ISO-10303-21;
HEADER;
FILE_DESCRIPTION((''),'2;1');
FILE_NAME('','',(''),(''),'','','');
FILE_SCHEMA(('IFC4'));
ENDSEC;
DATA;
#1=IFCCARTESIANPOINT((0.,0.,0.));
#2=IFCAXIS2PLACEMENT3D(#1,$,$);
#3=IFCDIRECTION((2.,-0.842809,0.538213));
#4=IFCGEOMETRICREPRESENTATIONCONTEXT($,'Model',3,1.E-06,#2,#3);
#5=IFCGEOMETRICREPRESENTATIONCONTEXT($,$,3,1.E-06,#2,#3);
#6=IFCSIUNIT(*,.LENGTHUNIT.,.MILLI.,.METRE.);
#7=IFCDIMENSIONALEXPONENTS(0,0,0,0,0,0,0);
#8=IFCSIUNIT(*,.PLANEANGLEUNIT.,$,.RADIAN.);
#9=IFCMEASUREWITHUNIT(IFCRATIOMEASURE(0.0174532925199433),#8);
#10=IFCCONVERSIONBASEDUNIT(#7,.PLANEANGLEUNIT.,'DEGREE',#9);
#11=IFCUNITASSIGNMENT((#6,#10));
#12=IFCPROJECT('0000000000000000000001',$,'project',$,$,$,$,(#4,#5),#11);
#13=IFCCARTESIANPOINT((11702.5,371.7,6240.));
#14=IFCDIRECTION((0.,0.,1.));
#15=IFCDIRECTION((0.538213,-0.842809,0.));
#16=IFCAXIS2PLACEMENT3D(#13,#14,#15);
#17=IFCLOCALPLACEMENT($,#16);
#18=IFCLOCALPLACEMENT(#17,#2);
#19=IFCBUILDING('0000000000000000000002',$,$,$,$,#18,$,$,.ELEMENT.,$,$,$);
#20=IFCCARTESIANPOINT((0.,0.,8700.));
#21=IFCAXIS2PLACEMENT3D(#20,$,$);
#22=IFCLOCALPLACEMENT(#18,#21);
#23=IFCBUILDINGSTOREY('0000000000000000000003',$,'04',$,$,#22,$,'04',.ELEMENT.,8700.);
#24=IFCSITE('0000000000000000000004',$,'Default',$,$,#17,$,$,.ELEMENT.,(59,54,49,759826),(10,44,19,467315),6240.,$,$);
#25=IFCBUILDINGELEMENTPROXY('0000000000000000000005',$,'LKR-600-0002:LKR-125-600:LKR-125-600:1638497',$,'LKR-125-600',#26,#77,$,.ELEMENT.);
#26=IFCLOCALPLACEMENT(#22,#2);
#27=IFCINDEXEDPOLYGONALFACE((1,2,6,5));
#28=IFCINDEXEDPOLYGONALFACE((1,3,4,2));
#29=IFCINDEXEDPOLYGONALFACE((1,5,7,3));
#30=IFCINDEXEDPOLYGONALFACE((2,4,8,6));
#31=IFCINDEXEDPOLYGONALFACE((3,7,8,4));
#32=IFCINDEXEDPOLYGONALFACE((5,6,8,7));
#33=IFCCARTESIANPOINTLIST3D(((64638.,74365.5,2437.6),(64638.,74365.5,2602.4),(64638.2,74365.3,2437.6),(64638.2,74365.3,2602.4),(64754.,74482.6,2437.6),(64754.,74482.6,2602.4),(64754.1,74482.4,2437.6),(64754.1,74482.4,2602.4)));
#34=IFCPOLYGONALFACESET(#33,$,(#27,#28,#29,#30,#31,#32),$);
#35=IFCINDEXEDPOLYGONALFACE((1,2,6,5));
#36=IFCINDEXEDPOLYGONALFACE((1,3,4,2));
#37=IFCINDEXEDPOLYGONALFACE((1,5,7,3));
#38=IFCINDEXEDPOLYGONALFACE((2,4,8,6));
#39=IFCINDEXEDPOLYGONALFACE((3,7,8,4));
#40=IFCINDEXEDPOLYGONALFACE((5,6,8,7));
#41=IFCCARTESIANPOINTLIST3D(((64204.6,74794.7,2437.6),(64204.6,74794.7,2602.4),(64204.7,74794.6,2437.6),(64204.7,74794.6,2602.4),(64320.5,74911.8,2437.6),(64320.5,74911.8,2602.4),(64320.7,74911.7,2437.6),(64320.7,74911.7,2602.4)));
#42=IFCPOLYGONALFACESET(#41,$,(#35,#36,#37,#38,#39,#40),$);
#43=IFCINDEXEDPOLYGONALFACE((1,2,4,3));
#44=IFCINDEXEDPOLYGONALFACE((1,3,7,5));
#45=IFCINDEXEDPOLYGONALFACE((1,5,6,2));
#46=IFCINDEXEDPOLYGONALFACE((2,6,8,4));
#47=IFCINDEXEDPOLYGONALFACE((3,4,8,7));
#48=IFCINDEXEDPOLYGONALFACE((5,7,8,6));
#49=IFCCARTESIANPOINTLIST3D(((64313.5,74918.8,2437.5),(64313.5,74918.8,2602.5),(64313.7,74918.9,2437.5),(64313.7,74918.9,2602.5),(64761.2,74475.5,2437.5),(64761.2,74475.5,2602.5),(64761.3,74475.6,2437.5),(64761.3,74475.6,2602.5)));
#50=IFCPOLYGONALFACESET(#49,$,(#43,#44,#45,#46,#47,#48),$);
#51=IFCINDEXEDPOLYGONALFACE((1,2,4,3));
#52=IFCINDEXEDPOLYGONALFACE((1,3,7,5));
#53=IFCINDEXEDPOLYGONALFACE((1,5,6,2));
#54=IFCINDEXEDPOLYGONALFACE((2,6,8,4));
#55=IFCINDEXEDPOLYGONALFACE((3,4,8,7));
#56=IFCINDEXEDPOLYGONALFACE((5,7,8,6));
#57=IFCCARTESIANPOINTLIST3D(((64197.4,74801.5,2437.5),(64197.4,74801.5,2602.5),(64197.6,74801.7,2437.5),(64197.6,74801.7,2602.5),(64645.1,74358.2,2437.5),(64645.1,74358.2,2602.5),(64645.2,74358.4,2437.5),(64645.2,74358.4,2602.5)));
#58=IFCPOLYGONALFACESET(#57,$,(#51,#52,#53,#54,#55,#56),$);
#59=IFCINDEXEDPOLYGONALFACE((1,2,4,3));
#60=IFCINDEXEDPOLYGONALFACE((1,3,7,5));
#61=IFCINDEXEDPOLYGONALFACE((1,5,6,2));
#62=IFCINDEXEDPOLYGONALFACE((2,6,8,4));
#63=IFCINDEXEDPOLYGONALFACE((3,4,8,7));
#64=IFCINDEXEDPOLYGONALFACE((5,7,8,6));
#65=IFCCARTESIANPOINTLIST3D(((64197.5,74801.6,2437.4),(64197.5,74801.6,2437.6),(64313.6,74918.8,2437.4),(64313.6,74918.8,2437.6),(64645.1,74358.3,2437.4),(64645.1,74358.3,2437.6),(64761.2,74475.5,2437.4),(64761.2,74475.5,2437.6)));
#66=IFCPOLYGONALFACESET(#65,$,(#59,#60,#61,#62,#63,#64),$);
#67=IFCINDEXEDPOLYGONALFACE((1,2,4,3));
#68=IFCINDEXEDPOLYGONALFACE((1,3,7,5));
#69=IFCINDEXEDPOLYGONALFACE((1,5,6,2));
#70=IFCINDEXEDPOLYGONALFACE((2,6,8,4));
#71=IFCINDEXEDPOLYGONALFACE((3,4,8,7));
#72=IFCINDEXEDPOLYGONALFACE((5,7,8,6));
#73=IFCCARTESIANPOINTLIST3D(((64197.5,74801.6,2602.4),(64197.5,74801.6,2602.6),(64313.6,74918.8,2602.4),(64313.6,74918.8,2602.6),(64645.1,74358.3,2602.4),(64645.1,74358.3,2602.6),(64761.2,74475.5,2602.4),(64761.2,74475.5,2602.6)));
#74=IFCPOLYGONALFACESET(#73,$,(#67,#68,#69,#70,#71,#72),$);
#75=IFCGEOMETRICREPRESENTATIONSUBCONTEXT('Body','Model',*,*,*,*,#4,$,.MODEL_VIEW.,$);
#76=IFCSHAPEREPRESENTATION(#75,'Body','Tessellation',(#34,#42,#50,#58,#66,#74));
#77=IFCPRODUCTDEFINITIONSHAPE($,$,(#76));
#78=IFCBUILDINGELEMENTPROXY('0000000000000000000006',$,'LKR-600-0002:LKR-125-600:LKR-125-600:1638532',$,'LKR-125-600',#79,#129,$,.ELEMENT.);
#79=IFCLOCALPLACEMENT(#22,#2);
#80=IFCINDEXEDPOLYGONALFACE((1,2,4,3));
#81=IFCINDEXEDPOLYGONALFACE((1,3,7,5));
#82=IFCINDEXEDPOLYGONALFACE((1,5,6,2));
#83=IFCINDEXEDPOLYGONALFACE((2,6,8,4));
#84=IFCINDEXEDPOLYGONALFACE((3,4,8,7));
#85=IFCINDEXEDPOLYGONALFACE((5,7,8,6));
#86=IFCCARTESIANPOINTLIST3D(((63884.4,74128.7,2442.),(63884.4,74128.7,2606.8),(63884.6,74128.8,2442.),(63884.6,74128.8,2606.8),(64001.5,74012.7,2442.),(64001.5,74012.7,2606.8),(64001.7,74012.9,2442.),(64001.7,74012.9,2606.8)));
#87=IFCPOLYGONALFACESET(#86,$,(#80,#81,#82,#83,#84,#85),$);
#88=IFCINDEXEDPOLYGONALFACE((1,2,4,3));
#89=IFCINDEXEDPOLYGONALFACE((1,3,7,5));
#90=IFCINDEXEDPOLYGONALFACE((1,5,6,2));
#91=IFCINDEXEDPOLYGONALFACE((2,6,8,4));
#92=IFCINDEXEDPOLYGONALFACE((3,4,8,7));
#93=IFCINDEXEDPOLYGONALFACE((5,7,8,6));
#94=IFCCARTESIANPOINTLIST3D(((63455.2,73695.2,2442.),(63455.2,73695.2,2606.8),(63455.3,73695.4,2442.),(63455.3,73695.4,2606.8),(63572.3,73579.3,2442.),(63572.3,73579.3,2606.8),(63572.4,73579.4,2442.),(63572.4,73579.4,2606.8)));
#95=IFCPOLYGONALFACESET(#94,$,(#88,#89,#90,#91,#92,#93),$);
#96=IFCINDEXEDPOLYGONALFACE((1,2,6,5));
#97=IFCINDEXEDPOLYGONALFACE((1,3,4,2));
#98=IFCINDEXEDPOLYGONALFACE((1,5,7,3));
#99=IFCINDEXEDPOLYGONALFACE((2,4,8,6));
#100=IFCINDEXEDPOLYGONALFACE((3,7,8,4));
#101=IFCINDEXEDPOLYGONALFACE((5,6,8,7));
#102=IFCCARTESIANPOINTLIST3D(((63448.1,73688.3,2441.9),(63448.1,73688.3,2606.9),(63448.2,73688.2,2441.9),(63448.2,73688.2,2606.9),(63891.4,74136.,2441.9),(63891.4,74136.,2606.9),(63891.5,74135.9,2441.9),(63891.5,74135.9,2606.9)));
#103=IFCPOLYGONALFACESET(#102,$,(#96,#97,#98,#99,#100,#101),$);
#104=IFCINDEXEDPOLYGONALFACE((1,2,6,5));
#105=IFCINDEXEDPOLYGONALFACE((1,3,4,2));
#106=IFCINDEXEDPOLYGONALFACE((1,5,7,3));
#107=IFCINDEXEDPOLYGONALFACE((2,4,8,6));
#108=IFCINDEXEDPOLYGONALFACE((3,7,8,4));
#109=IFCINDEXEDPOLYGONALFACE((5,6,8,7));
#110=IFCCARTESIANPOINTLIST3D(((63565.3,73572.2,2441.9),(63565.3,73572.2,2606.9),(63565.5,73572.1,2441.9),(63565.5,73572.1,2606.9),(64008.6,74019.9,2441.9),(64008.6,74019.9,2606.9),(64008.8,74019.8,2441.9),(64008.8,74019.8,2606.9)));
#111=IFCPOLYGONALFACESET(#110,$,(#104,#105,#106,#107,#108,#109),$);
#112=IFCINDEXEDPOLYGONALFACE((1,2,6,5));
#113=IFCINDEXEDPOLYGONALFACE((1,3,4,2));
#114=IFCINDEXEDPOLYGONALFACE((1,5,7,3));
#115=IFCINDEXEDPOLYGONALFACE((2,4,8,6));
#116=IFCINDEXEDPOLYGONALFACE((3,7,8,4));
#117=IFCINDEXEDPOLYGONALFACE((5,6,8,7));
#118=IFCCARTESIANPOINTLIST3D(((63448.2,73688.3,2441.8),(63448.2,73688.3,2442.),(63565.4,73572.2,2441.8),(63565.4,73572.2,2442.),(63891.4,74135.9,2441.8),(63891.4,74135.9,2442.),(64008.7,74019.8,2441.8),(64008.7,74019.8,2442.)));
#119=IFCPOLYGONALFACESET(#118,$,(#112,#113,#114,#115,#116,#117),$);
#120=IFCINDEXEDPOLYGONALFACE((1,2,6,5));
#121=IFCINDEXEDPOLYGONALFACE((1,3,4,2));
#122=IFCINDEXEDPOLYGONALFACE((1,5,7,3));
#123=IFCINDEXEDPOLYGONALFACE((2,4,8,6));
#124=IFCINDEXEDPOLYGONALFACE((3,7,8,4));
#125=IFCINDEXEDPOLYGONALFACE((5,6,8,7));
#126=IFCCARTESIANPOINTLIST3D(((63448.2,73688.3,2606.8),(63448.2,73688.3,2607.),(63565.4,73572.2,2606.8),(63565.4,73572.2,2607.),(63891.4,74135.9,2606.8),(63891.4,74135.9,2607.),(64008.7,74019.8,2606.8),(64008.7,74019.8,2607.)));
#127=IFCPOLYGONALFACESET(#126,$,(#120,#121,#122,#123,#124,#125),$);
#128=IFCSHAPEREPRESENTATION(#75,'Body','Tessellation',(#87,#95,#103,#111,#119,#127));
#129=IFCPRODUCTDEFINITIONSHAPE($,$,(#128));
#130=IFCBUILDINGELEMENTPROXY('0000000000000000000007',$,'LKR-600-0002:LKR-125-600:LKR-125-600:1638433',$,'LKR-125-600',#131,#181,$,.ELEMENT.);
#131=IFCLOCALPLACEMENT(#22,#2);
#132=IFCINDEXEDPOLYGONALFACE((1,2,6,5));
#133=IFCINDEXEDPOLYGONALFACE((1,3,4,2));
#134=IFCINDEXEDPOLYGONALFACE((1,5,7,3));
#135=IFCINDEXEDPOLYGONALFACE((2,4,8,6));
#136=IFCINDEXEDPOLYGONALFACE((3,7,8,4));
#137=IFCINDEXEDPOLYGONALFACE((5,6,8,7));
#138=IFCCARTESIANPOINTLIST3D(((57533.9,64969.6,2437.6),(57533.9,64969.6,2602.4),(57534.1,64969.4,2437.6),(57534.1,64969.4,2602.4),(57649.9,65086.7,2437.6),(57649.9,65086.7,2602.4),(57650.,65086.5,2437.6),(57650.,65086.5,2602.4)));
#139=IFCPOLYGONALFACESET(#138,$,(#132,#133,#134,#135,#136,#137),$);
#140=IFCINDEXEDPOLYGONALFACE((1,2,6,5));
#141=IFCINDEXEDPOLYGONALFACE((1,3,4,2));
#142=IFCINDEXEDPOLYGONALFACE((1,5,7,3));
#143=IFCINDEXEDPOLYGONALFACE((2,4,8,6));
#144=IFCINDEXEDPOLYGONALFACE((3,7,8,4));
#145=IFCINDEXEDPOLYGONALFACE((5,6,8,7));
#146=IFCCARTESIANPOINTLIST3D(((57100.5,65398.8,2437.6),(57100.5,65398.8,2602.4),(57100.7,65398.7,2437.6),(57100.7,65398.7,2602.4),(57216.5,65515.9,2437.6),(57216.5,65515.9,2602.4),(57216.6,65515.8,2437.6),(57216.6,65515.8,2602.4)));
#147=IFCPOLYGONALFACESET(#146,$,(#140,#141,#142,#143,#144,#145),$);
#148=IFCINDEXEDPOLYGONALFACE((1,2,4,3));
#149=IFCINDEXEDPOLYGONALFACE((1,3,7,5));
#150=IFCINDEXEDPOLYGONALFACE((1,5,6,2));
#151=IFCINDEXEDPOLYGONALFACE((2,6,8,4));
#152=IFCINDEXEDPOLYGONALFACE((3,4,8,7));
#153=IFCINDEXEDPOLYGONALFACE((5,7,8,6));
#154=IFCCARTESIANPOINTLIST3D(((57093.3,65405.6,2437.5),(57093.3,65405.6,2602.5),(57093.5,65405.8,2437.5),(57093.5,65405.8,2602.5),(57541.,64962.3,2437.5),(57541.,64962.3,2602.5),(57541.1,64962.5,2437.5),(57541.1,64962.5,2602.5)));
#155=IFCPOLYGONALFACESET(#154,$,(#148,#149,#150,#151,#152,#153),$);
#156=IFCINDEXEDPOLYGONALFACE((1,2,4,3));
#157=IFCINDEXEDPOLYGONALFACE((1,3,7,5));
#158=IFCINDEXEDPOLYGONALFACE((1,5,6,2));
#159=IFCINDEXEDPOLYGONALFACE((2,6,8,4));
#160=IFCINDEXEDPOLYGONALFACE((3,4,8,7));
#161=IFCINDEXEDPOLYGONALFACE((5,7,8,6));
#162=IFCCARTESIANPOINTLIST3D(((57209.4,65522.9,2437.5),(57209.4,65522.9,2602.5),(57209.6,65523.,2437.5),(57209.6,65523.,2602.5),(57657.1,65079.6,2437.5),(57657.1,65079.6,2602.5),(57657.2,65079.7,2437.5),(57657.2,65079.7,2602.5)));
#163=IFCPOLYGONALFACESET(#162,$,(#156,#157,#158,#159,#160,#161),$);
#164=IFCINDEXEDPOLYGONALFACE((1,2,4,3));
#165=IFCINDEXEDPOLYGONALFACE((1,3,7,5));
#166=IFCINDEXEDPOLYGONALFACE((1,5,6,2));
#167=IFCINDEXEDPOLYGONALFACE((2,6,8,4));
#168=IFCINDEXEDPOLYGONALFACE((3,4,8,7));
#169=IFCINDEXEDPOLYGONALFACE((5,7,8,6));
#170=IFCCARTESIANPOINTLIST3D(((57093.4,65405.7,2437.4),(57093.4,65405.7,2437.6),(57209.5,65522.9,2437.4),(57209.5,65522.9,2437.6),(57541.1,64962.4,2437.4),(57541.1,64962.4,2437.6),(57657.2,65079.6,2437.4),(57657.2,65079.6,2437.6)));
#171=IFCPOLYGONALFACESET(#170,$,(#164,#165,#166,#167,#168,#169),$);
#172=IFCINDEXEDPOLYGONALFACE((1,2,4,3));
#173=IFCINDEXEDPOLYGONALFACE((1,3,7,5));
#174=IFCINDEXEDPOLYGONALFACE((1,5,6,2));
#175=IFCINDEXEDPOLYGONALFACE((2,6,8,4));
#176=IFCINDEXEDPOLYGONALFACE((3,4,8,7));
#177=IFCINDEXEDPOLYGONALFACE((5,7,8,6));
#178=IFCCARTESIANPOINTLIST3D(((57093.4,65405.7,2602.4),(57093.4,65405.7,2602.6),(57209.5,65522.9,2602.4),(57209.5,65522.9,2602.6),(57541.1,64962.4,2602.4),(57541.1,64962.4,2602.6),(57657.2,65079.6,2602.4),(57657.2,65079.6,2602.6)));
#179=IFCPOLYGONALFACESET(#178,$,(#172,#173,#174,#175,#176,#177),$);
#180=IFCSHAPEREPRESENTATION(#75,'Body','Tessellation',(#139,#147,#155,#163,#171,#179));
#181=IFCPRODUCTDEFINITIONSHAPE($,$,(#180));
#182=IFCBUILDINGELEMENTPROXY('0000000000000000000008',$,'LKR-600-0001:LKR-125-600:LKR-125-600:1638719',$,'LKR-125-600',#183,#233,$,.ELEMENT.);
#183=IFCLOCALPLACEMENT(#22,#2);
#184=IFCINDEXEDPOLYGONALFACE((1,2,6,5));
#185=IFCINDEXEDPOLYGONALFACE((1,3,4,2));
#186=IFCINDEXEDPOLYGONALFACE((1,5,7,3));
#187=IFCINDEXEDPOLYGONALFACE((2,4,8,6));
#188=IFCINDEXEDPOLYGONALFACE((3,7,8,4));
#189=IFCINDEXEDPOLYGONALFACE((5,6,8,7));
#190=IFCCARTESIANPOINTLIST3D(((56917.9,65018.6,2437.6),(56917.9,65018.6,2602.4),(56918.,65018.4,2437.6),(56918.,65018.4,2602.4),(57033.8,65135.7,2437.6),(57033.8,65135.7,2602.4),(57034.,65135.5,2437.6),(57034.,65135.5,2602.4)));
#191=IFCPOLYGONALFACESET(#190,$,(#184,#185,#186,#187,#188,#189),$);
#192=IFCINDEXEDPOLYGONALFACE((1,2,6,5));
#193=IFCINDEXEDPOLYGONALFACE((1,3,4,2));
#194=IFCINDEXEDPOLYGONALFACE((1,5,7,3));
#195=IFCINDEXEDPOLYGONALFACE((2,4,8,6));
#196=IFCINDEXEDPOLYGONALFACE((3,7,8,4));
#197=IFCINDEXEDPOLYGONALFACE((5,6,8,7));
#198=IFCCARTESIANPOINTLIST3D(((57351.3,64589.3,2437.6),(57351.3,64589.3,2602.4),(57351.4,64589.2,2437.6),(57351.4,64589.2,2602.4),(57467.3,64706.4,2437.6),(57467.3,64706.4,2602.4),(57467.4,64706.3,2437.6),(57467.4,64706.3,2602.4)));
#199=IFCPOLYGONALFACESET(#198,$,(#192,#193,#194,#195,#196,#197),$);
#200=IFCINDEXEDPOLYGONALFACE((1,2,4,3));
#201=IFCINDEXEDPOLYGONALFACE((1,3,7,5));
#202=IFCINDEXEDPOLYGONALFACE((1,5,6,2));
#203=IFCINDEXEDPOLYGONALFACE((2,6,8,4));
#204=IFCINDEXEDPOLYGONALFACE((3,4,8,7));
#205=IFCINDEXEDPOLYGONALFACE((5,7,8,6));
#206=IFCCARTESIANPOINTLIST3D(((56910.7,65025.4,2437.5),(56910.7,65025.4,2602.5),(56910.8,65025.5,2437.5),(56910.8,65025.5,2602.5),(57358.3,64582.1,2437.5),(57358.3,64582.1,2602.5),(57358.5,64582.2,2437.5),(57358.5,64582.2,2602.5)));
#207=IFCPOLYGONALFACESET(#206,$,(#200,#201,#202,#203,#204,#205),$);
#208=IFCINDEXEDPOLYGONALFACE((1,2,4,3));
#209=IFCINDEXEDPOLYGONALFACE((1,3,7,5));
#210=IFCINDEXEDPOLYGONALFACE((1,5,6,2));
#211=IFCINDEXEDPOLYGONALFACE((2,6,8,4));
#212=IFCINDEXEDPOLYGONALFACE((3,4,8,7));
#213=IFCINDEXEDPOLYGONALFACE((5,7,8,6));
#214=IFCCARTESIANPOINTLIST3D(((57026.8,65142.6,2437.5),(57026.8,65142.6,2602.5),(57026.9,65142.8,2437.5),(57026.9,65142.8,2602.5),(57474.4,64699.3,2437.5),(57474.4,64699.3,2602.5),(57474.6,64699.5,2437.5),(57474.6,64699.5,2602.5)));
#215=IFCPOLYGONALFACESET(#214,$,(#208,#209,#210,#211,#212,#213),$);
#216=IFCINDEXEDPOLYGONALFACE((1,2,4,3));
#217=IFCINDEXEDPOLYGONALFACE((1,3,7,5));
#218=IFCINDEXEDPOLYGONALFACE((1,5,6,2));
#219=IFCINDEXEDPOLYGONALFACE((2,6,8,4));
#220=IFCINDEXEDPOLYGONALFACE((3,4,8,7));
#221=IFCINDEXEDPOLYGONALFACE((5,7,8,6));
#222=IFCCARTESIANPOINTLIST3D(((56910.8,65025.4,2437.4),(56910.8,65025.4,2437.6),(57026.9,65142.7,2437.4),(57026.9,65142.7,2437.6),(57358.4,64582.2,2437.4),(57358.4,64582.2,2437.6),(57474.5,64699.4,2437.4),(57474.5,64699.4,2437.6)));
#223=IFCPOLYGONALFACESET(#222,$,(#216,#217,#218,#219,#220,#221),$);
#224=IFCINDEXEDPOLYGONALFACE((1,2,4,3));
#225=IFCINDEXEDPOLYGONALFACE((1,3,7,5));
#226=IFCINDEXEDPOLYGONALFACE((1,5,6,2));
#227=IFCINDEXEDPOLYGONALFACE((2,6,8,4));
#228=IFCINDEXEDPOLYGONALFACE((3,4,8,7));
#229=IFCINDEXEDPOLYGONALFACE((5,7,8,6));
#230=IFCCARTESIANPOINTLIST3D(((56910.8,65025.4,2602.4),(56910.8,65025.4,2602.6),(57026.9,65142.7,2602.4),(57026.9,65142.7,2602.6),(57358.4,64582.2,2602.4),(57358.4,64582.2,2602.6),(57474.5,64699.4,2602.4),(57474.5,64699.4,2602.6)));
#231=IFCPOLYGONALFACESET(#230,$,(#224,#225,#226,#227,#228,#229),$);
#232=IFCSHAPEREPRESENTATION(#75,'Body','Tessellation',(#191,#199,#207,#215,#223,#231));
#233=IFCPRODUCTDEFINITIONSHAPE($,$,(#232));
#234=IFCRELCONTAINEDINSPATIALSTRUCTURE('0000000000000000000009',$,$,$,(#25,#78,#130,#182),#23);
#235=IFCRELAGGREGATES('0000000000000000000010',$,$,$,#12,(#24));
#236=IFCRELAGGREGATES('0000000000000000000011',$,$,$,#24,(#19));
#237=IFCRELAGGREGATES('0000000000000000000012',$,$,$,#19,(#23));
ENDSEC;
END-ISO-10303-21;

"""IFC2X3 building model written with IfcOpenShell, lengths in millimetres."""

from ifc_helpers import new_model, entity, si_unit, converted_unit, direction, frame, frame_2d, origin, place, context, subcontext, project, spatial, rectangle, extrude, source, transform, mapped, element, save


model = new_model("IFC2X3")

# Units and contexts
model_context = context("Model", 3, precision=1e-06, world=origin(), true_north=direction((2.0, -0.842809, 0.538213)))
context_of_model = context(None, 3, precision=1e-06, world=origin(), true_north=direction((2.0, -0.842809, 0.538213)))
body_context = subcontext(model_context, "Body", "Model", "MODEL_VIEW")
ifc_project = project(units=[si_unit("LENGTHUNIT", "METRE", prefix="MILLI"), converted_unit("PLANEANGLEUNIT", "DEGREE", entity("IfcRatioMeasure", 0.0174532925199433), si_unit("PLANEANGLEUNIT", "RADIAN"), dimensions=[0, 0, 0, 0, 0, 0, 0])], contexts=[model_context, context_of_model])

# Site, building, storey
site_placement = place(None, frame((11702.5, 371.7, 6240.0), z_axis=(0.0, 0.0, 1.0), x_axis=(0.538213, -0.842809, 0.0)))
site = spatial("IfcSite", under=ifc_project, at=site_placement, Name="Default", CompositionType="ELEMENT", RefLatitude=(59, 54, 49, 759826), RefLongitude=(10, 44, 19, 467315), RefElevation=6240.0)
building_placement = place(site_placement, origin())
building = spatial("IfcBuilding", under=site, at=building_placement, CompositionType="ELEMENT")
storey_placement = place(building_placement, frame((0.0, 0.0, 8700.0)))
storey = spatial("IfcBuildingStorey", under=building, at=storey_placement, Name="04", LongName="04", CompositionType="ELEMENT", Elevation=8700.0)

# Building element proxies
shared_shape_1 = source(origin(), body_context, "Body", "SweptSolid", [
    extrude(rectangle(XDim=0.2, YDim=164.8, at=frame_2d((0.0, 0.0), x_axis=(1.0, 0.0))), frame((305.0, 0.0, -82.4)), (0.0, 0.0, 1.0), 164.8),
    extrude(rectangle(XDim=0.2, YDim=164.8, at=frame_2d((0.0, 0.0), x_axis=(1.0, 0.0))), frame((-305.0, 0.0, -82.4)), (0.0, 0.0, 1.0), 164.8),
    extrude(rectangle(XDim=0.2, YDim=630.0, at=frame_2d((0.0, 0.0), x_axis=(1.0, 0.0))), frame((0.0, 82.5, -82.5), z_axis=(0.0, 0.0, 1.0), x_axis=(0.0, 1.0, 0.0)), (0.0, 0.0, 1.0), 165.0),
    extrude(rectangle(XDim=0.2, YDim=630.0, at=frame_2d((0.0, 0.0), x_axis=(1.0, 0.0))), frame((0.0, -82.5, -82.5), z_axis=(0.0, 0.0, 1.0), x_axis=(0.0, 1.0, 0.0)), (0.0, 0.0, 1.0), 165.0),
    extrude(rectangle(XDim=165.0, YDim=630.0, at=frame_2d((0.0, 0.0), x_axis=(1.0, 0.0))), frame((0.0, 0.0, -82.6), z_axis=(0.0, 0.0, 1.0), x_axis=(0.0, -1.0, 0.0)), (0.0, 0.0, 1.0), 0.2),
    extrude(rectangle(XDim=165.0, YDim=630.0, at=frame_2d((0.0, 0.0), x_axis=(1.0, 0.0))), frame((0.0, 0.0, 82.4), z_axis=(0.0, 0.0, 1.0), x_axis=(0.0, -1.0, 0.0)), (0.0, 0.0, 1.0), 0.2),
])
for number, where, z_axis, x_axis, name in (
    (1, (64479.4, 74638.6, 2520.0), (0.0, 0.0, 1.0), (0.710554, -0.703643, 0.0), "LKR-600-0002:LKR-125-600:LKR-125-600:1638497"),
    (2, (63728.4, 73854.1, 2524.4), (0.0, 0.0, 1.0), (0.703643, 0.710554, 0.0), "LKR-600-0002:LKR-125-600:LKR-125-600:1638532"),
):
    element("IfcBuildingElementProxy", number, at=place(storey_placement, frame(where, z_axis=z_axis, x_axis=x_axis)), inside=storey, Name=name, ObjectType="LKR-125-600", CompositionType="ELEMENT", context=body_context, shape_type="MappedRepresentation", body=[
        mapped(shared_shape_1, transform((0.0, 0.0, 0.0), scale=1.0)),
    ])
shared_shape_2 = source(origin(), body_context, "Body", "SweptSolid", [
    extrude(rectangle(XDim=164.8, YDim=0.2, at=frame_2d((0.0, 0.0), x_axis=(1.0, 0.0))), frame((305.0, 0.0, -82.4), z_axis=(0.0, 0.0, 1.0), x_axis=(0.0, -1.0, 0.0)), (0.0, 0.0, 1.0), 164.8),
    extrude(rectangle(XDim=164.8, YDim=0.2, at=frame_2d((0.0, 0.0), x_axis=(1.0, 0.0))), frame((-305.0, 0.0, -82.4), z_axis=(0.0, 0.0, 1.0), x_axis=(0.0, -1.0, 0.0)), (0.0, 0.0, 1.0), 164.8),
    extrude(rectangle(XDim=630.0, YDim=0.2, at=frame_2d((0.0, 0.0), x_axis=(1.0, 0.0))), frame((0.0, -82.5, -82.5), z_axis=(0.0, 0.0, 1.0), x_axis=(-1.0, 0.0, 0.0)), (0.0, 0.0, 1.0), 165.0),
    extrude(rectangle(XDim=630.0, YDim=0.2, at=frame_2d((0.0, 0.0), x_axis=(1.0, 0.0))), frame((0.0, 82.5, -82.5), z_axis=(0.0, 0.0, 1.0), x_axis=(-1.0, 0.0, 0.0)), (0.0, 0.0, 1.0), 165.0),
    extrude(rectangle(XDim=630.0, YDim=165.0, at=frame_2d((0.0, 0.0), x_axis=(1.0, 0.0))), frame((0.0, 0.0, -82.6)), (0.0, 0.0, 1.0), 0.2),
    extrude(rectangle(XDim=630.0, YDim=165.0, at=frame_2d((0.0, 0.0), x_axis=(1.0, 0.0))), frame((0.0, 0.0, 82.4)), (0.0, 0.0, 1.0), 0.2),
])
proxy_1_placement = place(storey_placement, frame((57375.3, 65242.7, 2520.0), z_axis=(0.0, 0.0, 1.0), x_axis=(0.710554, -0.703643, 0.0)))
element("IfcBuildingElementProxy", 3, at=proxy_1_placement, inside=storey, Name="LKR-600-0002:LKR-125-600:LKR-125-600:1638433", ObjectType="LKR-125-600", CompositionType="ELEMENT", context=body_context, shape_type="MappedRepresentation", body=[
    mapped(shared_shape_2, transform((0.0, 0.0, 0.0), scale=1.0)),
])
shared_shape_3 = source(origin(), body_context, "Body", "SweptSolid", [
    extrude(rectangle(XDim=0.2, YDim=164.8, at=frame_2d((0.0, 0.0), x_axis=(1.0, 0.0))), frame((305.0, 0.0, -82.4)), (0.0, 0.0, 1.0), 164.8),
    extrude(rectangle(XDim=0.2, YDim=164.8, at=frame_2d((0.0, 0.0), x_axis=(1.0, 0.0))), frame((-305.0, 0.0, -82.4)), (0.0, 0.0, 1.0), 164.8),
    extrude(rectangle(XDim=0.2, YDim=630.0, at=frame_2d((0.0, 0.0), x_axis=(1.0, 0.0))), frame((0.0, 82.5, -82.5), z_axis=(0.0, 0.0, 1.0), x_axis=(0.0, 1.0, 0.0)), (0.0, 0.0, 1.0), 165.0),
    extrude(rectangle(XDim=0.2, YDim=630.0, at=frame_2d((0.0, 0.0), x_axis=(1.0, 0.0))), frame((0.0, -82.5, -82.5), z_axis=(0.0, 0.0, 1.0), x_axis=(0.0, 1.0, 0.0)), (0.0, 0.0, 1.0), 165.0),
    extrude(rectangle(XDim=165.0, YDim=630.0, at=frame_2d((0.0, 0.0), x_axis=(1.0, 0.0))), frame((0.0, 0.0, -82.6), z_axis=(0.0, 0.0, 1.0), x_axis=(0.0, -1.0, 0.0)), (0.0, 0.0, 1.0), 0.2),
    extrude(rectangle(XDim=165.0, YDim=630.0, at=frame_2d((0.0, 0.0), x_axis=(1.0, 0.0))), frame((0.0, 0.0, 82.4), z_axis=(0.0, 0.0, 1.0), x_axis=(0.0, -1.0, 0.0)), (0.0, 0.0, 1.0), 0.2),
])
proxy_2_placement = place(storey_placement, frame((57192.6, 64862.4, 2520.0), z_axis=(0.0, 0.0, 1.0), x_axis=(-0.710554, 0.703643, 0.0)))
element("IfcBuildingElementProxy", 4, at=proxy_2_placement, inside=storey, Name="LKR-600-0001:LKR-125-600:LKR-125-600:1638719", ObjectType="LKR-125-600", CompositionType="ELEMENT", context=body_context, shape_type="MappedRepresentation", body=[
    mapped(shared_shape_3, transform((0.0, 0.0, 0.0), scale=1.0)),
])

save(model, "model.ifc")
